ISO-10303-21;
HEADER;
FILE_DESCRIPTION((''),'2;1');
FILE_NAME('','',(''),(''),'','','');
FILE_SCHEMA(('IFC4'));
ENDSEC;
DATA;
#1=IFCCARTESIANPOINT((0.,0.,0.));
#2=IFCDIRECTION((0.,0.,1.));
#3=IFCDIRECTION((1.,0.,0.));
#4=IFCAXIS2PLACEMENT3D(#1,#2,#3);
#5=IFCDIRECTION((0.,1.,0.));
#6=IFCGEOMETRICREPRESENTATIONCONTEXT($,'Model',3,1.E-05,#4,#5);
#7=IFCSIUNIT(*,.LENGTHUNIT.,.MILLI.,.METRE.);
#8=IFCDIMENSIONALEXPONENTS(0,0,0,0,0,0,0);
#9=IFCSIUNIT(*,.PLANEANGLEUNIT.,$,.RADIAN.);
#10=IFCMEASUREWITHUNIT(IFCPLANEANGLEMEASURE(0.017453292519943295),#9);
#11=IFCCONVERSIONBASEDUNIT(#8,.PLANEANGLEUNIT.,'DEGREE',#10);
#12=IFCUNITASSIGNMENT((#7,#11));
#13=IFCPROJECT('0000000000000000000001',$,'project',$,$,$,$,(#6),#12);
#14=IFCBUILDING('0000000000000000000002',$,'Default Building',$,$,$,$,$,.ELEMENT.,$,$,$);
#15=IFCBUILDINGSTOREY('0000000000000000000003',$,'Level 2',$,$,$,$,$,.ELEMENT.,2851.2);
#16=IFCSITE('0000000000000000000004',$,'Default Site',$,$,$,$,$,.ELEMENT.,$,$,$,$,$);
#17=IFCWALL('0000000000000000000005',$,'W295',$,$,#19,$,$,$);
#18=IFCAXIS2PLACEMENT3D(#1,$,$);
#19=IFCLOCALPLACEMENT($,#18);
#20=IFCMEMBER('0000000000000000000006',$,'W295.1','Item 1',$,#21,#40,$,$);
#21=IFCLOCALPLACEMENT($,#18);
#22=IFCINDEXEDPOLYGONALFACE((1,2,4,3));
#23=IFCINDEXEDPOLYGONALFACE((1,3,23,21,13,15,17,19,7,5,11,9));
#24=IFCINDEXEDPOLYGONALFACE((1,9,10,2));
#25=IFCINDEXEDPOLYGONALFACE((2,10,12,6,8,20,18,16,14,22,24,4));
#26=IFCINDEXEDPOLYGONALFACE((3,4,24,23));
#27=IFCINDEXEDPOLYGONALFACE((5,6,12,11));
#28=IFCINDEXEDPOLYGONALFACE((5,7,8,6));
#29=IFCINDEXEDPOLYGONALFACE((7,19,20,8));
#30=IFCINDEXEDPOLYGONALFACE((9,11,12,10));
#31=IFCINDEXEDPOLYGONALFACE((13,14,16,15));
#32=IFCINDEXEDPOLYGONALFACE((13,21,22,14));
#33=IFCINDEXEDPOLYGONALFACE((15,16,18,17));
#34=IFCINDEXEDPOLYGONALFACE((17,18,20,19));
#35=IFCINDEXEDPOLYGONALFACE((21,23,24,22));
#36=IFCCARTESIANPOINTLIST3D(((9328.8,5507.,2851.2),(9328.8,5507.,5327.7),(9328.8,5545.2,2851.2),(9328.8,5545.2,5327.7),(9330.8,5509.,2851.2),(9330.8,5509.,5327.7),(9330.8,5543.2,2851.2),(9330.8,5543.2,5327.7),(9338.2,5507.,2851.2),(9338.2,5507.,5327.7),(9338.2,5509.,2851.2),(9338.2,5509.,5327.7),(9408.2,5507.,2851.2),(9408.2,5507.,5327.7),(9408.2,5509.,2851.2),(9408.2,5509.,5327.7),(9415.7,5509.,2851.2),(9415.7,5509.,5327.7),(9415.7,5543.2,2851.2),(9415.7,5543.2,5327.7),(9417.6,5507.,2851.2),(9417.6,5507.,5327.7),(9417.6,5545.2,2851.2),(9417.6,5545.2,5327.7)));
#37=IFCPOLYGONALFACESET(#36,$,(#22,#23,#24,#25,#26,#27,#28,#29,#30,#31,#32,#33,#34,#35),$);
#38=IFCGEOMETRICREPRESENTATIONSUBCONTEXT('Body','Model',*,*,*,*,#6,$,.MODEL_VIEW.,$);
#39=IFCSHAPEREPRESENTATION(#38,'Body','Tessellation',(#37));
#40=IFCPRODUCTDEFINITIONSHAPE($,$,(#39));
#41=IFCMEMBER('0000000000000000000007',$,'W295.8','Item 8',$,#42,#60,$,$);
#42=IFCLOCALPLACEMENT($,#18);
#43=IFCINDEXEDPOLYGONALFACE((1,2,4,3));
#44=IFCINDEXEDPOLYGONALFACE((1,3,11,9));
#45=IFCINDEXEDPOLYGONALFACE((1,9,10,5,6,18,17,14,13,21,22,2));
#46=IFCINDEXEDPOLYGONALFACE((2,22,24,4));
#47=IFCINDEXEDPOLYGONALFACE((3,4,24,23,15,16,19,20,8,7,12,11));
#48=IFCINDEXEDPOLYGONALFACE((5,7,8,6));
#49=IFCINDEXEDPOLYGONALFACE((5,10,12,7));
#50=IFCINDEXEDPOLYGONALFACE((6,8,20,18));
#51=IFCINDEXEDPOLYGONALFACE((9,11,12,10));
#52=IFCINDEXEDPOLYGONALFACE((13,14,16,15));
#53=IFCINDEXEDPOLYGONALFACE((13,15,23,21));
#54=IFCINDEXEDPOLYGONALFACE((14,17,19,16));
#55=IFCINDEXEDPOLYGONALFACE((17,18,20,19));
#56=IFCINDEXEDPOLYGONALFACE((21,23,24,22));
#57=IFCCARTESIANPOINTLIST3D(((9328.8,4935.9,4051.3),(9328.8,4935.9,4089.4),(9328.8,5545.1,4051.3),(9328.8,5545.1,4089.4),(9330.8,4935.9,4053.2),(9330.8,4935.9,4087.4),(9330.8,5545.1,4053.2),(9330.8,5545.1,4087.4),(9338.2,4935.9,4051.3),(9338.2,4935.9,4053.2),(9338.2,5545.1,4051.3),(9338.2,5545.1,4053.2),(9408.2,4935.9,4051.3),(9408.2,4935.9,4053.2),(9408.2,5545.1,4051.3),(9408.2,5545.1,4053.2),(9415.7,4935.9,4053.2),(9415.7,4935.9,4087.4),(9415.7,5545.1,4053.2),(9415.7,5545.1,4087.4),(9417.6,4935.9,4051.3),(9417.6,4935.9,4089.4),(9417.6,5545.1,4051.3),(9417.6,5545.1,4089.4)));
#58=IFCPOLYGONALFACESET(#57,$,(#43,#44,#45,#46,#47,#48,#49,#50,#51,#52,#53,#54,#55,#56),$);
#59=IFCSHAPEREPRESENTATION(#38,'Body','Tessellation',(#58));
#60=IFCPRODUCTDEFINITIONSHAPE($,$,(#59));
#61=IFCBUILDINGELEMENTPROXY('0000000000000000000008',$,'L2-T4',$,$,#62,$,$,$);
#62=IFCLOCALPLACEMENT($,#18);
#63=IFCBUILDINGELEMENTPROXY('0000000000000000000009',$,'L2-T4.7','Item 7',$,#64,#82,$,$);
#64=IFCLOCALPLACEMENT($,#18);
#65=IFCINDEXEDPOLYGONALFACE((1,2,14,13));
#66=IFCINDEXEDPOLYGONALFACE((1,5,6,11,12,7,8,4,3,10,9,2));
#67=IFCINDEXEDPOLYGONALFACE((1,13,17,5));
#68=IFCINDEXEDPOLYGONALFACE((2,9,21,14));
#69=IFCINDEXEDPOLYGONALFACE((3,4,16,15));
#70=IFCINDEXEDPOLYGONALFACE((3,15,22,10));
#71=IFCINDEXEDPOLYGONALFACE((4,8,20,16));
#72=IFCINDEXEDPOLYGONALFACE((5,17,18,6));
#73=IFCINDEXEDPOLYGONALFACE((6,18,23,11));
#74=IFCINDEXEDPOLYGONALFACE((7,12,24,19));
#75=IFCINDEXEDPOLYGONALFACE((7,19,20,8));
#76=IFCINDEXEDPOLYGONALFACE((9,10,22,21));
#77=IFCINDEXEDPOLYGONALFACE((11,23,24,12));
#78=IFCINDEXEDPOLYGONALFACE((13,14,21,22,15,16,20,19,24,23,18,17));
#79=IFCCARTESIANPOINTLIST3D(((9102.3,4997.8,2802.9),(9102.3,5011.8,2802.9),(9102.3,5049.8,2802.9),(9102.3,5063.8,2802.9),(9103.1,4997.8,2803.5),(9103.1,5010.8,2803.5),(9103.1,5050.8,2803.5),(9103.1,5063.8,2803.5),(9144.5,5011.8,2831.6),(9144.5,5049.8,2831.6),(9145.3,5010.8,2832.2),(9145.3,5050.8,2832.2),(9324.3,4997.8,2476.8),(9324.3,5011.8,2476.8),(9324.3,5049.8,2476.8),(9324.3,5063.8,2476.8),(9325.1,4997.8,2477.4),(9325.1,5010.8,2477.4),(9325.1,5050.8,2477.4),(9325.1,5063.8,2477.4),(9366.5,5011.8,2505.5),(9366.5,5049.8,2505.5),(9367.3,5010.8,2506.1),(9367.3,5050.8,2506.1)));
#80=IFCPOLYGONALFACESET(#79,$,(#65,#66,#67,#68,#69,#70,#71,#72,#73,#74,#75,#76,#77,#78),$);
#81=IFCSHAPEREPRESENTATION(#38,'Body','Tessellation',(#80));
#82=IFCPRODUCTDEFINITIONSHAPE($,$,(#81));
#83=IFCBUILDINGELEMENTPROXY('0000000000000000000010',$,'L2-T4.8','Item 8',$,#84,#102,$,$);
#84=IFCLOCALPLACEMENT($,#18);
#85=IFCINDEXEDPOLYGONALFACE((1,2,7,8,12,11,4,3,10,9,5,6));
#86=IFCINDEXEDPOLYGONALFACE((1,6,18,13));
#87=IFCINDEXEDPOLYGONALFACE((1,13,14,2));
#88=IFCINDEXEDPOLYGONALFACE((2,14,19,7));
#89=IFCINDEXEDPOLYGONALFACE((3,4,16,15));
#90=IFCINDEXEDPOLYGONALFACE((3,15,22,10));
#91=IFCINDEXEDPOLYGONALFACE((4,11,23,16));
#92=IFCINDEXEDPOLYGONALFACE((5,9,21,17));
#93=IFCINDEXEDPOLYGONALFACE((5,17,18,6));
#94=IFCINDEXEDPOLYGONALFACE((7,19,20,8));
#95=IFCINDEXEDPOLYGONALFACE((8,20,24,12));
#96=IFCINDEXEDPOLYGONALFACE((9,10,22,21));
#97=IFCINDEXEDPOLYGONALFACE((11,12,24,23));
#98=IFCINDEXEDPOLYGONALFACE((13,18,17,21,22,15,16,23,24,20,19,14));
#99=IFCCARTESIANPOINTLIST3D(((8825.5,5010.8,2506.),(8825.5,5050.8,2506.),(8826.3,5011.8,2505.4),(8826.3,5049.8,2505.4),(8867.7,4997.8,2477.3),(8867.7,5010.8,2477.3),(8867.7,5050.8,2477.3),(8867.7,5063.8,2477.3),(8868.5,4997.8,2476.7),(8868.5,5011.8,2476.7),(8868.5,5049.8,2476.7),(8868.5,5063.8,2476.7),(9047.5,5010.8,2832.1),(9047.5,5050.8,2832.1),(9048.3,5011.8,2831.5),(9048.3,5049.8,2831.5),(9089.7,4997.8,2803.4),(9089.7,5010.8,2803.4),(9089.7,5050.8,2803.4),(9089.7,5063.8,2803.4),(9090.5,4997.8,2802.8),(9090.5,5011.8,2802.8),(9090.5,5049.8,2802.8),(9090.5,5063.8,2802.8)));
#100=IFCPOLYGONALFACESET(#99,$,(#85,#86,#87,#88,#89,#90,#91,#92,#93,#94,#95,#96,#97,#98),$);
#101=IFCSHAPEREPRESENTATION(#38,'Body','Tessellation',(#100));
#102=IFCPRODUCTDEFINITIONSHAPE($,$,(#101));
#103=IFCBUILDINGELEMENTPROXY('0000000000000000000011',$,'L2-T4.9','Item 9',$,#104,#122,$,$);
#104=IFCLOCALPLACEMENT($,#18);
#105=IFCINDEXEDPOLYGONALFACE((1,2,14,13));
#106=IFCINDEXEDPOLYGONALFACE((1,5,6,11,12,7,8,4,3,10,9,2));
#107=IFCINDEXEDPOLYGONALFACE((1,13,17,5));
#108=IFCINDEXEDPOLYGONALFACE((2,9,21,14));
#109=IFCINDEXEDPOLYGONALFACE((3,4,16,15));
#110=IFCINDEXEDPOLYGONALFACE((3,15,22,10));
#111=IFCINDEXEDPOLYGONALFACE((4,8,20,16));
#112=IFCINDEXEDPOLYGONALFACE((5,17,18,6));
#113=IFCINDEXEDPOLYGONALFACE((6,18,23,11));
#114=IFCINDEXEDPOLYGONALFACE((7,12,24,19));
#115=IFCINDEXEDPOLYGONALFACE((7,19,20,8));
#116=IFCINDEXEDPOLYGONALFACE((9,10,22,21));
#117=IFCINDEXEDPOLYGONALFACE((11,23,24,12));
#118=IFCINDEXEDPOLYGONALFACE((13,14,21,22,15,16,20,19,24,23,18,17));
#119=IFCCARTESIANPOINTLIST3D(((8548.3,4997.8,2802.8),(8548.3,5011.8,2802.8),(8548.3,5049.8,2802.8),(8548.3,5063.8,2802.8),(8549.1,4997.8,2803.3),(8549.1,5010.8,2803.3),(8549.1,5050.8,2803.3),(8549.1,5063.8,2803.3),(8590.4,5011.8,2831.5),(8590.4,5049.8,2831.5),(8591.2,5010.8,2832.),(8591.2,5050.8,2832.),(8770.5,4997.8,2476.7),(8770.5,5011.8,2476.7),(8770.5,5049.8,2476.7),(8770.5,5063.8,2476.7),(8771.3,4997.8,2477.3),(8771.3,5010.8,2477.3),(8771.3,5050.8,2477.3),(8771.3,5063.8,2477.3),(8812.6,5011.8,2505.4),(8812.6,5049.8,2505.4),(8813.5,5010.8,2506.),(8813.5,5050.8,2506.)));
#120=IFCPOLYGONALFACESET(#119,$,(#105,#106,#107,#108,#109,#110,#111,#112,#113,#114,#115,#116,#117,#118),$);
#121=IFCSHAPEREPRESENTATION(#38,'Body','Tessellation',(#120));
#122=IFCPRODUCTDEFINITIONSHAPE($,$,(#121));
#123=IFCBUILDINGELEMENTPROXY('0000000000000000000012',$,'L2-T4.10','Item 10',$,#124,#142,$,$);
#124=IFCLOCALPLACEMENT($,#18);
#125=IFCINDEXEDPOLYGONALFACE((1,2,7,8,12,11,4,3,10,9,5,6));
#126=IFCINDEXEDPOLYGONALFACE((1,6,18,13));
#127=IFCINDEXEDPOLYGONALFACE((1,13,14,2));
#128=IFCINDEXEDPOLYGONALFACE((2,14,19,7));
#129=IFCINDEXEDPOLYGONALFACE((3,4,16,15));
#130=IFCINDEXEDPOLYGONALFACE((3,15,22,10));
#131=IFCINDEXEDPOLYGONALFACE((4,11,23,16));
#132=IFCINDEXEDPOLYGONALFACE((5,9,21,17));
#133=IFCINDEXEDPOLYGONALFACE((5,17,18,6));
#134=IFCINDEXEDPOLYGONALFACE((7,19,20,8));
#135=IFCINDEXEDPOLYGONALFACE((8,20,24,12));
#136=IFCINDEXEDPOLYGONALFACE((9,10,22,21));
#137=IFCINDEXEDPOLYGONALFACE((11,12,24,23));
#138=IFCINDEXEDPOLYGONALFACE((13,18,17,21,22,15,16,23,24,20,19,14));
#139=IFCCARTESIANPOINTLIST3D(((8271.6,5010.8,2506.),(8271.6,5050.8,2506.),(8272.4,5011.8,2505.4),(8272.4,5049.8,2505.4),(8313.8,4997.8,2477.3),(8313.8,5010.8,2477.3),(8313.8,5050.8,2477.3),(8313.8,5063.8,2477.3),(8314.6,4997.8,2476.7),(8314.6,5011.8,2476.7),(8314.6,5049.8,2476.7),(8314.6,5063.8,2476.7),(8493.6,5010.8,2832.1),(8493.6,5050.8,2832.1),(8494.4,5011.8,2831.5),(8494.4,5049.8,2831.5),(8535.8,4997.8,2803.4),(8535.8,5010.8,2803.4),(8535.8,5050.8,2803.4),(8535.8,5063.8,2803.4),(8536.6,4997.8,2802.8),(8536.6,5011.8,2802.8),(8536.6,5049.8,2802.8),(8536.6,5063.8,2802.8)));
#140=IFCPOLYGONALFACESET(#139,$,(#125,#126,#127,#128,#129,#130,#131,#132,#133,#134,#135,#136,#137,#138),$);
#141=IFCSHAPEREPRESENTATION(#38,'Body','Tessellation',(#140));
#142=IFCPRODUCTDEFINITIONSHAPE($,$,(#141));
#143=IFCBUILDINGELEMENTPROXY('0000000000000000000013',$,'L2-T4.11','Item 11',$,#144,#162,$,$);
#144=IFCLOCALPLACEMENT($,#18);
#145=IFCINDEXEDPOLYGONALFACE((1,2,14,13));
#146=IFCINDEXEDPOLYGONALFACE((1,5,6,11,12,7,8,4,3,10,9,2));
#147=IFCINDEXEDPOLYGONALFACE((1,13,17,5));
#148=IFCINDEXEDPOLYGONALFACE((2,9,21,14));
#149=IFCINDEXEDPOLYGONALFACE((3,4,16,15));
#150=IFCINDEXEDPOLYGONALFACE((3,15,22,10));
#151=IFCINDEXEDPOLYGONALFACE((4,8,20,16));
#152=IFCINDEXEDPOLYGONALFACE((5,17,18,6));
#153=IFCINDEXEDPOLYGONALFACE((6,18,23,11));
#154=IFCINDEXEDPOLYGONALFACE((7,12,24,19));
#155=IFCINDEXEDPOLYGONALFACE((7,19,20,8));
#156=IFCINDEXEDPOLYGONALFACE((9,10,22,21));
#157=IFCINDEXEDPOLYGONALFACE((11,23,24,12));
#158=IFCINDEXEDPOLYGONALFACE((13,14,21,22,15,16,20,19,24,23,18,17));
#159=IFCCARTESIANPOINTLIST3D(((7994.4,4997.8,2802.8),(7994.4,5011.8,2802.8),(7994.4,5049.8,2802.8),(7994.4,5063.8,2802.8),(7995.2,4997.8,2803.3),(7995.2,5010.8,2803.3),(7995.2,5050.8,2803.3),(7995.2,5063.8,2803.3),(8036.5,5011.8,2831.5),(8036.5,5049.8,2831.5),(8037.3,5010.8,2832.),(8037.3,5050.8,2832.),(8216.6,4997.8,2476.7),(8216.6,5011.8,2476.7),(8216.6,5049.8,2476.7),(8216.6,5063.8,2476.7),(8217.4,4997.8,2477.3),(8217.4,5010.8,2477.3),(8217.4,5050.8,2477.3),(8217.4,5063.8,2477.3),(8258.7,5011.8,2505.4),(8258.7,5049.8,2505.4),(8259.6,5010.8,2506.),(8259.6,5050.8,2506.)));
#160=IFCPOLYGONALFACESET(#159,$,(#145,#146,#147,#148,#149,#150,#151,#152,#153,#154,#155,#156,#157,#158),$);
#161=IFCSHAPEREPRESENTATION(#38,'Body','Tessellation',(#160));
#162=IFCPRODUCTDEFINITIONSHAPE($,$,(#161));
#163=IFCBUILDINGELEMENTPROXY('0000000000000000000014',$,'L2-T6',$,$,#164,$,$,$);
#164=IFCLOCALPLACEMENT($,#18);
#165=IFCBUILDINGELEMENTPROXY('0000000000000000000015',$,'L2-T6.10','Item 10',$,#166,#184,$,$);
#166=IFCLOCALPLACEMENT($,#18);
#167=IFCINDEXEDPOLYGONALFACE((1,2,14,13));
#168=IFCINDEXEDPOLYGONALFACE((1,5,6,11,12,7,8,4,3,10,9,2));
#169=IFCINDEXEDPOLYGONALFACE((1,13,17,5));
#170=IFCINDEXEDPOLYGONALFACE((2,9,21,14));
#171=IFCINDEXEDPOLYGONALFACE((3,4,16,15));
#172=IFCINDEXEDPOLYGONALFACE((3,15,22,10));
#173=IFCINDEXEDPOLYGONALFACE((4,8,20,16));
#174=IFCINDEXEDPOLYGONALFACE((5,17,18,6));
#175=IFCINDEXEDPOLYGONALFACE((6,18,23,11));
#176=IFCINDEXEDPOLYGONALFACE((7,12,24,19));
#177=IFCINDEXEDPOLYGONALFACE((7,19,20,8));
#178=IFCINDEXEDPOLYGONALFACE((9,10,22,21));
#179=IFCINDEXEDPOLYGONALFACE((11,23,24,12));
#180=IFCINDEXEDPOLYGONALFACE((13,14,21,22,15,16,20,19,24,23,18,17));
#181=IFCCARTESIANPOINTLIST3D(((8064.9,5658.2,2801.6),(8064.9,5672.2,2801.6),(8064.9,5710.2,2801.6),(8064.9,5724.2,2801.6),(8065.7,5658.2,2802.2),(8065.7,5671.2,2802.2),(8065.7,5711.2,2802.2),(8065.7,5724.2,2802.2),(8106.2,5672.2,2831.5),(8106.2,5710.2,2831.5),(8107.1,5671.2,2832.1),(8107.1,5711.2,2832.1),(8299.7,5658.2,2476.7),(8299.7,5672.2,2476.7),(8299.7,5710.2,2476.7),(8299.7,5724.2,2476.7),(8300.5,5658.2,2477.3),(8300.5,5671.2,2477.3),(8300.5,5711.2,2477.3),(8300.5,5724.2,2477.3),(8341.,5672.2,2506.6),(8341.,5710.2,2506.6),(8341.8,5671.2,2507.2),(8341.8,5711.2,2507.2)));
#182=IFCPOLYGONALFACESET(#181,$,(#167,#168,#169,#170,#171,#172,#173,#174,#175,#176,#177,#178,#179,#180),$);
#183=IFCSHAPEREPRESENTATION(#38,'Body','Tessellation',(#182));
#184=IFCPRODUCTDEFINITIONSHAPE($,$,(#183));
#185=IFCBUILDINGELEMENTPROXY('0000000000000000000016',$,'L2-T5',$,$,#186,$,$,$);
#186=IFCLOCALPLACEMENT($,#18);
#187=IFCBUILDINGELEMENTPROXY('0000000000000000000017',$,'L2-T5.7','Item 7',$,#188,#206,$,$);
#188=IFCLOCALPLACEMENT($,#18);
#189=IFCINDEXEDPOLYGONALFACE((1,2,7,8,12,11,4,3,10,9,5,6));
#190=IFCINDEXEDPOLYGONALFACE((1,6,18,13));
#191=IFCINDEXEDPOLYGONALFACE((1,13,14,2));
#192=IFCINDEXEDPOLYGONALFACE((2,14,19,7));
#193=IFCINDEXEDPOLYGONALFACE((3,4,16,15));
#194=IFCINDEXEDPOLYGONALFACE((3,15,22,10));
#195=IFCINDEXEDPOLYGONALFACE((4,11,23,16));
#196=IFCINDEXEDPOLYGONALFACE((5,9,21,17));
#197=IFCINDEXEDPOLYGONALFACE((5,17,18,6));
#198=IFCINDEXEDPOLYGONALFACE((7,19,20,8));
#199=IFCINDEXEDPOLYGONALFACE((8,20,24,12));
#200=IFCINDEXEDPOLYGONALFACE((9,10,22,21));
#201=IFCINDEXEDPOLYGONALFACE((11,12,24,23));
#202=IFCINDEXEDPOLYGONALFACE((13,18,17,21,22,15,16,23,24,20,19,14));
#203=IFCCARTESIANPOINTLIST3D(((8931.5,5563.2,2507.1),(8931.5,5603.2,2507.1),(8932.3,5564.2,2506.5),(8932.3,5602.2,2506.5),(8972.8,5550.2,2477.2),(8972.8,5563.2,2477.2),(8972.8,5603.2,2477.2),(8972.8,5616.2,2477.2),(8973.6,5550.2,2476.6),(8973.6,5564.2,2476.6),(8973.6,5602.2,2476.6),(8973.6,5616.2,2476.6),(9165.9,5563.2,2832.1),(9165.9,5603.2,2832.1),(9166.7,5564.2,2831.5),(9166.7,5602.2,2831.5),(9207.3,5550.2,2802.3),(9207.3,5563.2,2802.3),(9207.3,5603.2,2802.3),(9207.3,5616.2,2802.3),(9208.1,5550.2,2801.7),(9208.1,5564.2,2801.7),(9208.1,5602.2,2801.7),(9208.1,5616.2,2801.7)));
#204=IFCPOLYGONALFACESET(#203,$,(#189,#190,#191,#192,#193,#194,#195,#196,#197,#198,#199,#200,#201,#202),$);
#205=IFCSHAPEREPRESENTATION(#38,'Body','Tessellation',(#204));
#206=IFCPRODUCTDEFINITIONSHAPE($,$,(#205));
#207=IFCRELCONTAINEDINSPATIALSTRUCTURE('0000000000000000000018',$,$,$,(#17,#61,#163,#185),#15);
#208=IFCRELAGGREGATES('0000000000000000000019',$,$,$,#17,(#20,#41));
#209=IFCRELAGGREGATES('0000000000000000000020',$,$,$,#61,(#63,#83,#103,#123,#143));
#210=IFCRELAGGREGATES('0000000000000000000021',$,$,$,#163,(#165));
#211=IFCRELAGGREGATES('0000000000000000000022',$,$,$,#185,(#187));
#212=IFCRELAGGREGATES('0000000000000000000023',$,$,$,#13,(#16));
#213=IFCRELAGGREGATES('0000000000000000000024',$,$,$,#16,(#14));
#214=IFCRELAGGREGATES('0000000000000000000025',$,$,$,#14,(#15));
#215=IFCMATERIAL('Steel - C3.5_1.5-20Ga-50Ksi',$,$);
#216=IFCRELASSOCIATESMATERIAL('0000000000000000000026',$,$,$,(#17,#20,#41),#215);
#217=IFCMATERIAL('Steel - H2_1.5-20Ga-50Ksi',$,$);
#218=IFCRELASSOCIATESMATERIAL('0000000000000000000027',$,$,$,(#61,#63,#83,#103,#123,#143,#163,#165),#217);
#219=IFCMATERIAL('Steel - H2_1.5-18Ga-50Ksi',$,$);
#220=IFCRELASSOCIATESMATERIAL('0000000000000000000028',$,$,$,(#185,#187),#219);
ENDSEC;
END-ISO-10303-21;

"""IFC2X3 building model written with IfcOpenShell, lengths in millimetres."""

from ifc_helpers import new_model, entity, si_unit, converted_unit, direction, frame, origin, origin_with_axes, origin_2d_with_axis, place, context, subcontext, project, spatial, polyline, c_section, outline, extrude, material, element, aggregate, save


model = new_model("IFC2X3")

# Units and contexts
model_context = context("Model", 3, precision=1e-05, world=origin_with_axes(), true_north=direction((0.0, 1.0, 0.0)))
body_context = subcontext(model_context, "Body", "Model", "MODEL_VIEW")
ifc_project = project(units=[si_unit("LENGTHUNIT", "METRE", prefix="MILLI"), converted_unit("PLANEANGLEUNIT", "DEGREE", entity("IfcPlaneAngleMeasure", 0.017453292519943295), si_unit("PLANEANGLEUNIT", "RADIAN"), dimensions=[0, 0, 0, 0, 0, 0, 0])], contexts=[model_context])

# Site, building, storey
site = spatial("IfcSite", under=ifc_project, Name="Default Site", CompositionType="ELEMENT")
building = spatial("IfcBuilding", under=site, Name="Default Building", CompositionType="ELEMENT")
storey = spatial("IfcBuildingStorey", under=building, Name="Level 2", CompositionType="ELEMENT", Elevation=2851.2)

# Wall, members
ifc_material_1 = material(Name="Steel - C3.5_1.5-20Ga-50Ksi")
wall_1 = element("IfcWall", 1, inside=storey, material=ifc_material_1, Name="W295")
member_1_placement = place(None, frame((9373.2, 5526.1, 2851.2), z_axis=(0.0, 0.0, 1.0), x_axis=(0.0, -1.0, 0.0)))
member_1 = element("IfcMember", 2, at=member_1_placement, material=ifc_material_1, Name="W295.1", Description="Item 1", context=body_context, shape_type="SweptSolid", body=[
    extrude(c_section(Depth=88.9, Width=38.1, WallThickness=2.0, Girth=9.5, at=origin_2d_with_axis()), origin(), (0.0, 0.0, 1.0), 2476.5),
])
member_2_placement = place(None, frame((9373.2, 5545.1, 4070.3), z_axis=(0.0, -1.0, 0.0), x_axis=(0.0, 0.0, -1.0)))
member_2 = element("IfcMember", 3, at=member_2_placement, material=ifc_material_1, Name="W295.8", Description="Item 8", context=body_context, shape_type="SweptSolid", body=[
    extrude(c_section(Depth=88.9, Width=38.1, WallThickness=2.0, Girth=9.5, at=origin_2d_with_axis()), origin(), (0.0, 0.0, 1.0), 609.2),
])
aggregate(wall_1, [member_1, member_2])

# Building element proxies
ifc_material_2 = material(Name="Steel - H2_1.5-20Ga-50Ksi")
proxy_1 = element("IfcBuildingElementProxy", 4, inside=storey, material=ifc_material_2, Name="L2-T4")
proxy_2_placement = place(None, frame((9324.3, 5063.8, 2476.8), z_axis=(-0.563, 0.0, 0.827), x_axis=(0.0, -40.0, 0.0)))
proxy_2 = element("IfcBuildingElementProxy", 5, at=proxy_2_placement, material=ifc_material_2, Name="L2-T4.7", Description="Item 7", context=body_context, shape_type="SweptSolid", body=[
    extrude(outline(polyline([(0.0, 0.0), (14.0, 0.0), (14.0, 51.0), (52.0, 51.0), (52.0, 0.0), (66.0, 0.0), (66.0, 1.0), (53.0, 1.0), (53.0, 52.0), (13.0, 52.0), (13.0, 1.0), (0.0, 1.0), (0.0, 0.0)])), origin(), (0.0, 0.0, 1.0), 394.5),
])
proxy_3_placement = place(None, frame((9090.5, 5063.8, 2802.8), z_axis=(-0.563, 0.0, -0.827), x_axis=(0.0, -40.0, 0.0)))
proxy_3 = element("IfcBuildingElementProxy", 6, at=proxy_3_placement, material=ifc_material_2, Name="L2-T4.8", Description="Item 8", context=body_context, shape_type="SweptSolid", body=[
    extrude(outline(polyline([(0.0, 0.0), (14.0, 0.0), (14.0, 51.0), (52.0, 51.0), (52.0, 0.0), (66.0, 0.0), (66.0, 1.0), (53.0, 1.0), (53.0, 52.0), (13.0, 52.0), (13.0, 1.0), (0.0, 1.0), (0.0, 0.0)])), origin(), (0.0, 0.0, 1.0), 394.5),
])
proxy_4_placement = place(None, frame((8770.5, 5063.8, 2476.7), z_axis=(-0.563, 0.0, 0.826), x_axis=(0.0, -40.0, 0.0)))
proxy_4 = element("IfcBuildingElementProxy", 7, at=proxy_4_placement, material=ifc_material_2, Name="L2-T4.9", Description="Item 9", context=body_context, shape_type="SweptSolid", body=[
    extrude(outline(polyline([(0.0, 0.0), (14.0, 0.0), (14.0, 51.0), (52.0, 51.0), (52.0, 0.0), (66.0, 0.0), (66.0, 1.0), (53.0, 1.0), (53.0, 52.0), (13.0, 52.0), (13.0, 1.0), (0.0, 1.0), (0.0, 0.0)])), origin(), (0.0, 0.0, 1.0), 394.6),
])
proxy_5_placement = place(None, frame((8536.6, 5063.8, 2802.8), z_axis=(-0.563, 0.0, -0.827), x_axis=(0.0, -40.0, 0.0)))
proxy_5 = element("IfcBuildingElementProxy", 8, at=proxy_5_placement, material=ifc_material_2, Name="L2-T4.10", Description="Item 10", context=body_context, shape_type="SweptSolid", body=[
    extrude(outline(polyline([(0.0, 0.0), (14.0, 0.0), (14.0, 51.0), (52.0, 51.0), (52.0, 0.0), (66.0, 0.0), (66.0, 1.0), (53.0, 1.0), (53.0, 52.0), (13.0, 52.0), (13.0, 1.0), (0.0, 1.0), (0.0, 0.0)])), origin(), (0.0, 0.0, 1.0), 394.5),
])
proxy_6_placement = place(None, frame((8216.6, 5063.8, 2476.7), z_axis=(-0.563, 0.0, 0.826), x_axis=(0.0, -40.0, 0.0)))
proxy_6 = element("IfcBuildingElementProxy", 9, at=proxy_6_placement, material=ifc_material_2, Name="L2-T4.11", Description="Item 11", context=body_context, shape_type="SweptSolid", body=[
    extrude(outline(polyline([(0.0, 0.0), (14.0, 0.0), (14.0, 51.0), (52.0, 51.0), (52.0, 0.0), (66.0, 0.0), (66.0, 1.0), (53.0, 1.0), (53.0, 52.0), (13.0, 52.0), (13.0, 1.0), (0.0, 1.0), (0.0, 0.0)])), origin(), (0.0, 0.0, 1.0), 394.6),
])
aggregate(proxy_1, [proxy_2, proxy_3, proxy_4, proxy_5, proxy_6])
proxy_7 = element("IfcBuildingElementProxy", 10, inside=storey, material=ifc_material_2, Name="L2-T6")
proxy_8_placement = place(None, frame((8299.7, 5724.2, 2476.7), z_axis=(-0.586, 0.0, 0.811), x_axis=(0.0, -40.0, 0.0)))
proxy_8 = element("IfcBuildingElementProxy", 11, at=proxy_8_placement, material=ifc_material_2, Name="L2-T6.10", Description="Item 10", context=body_context, shape_type="SweptSolid", body=[
    extrude(outline(polyline([(0.0, 0.0), (14.0, 0.0), (14.0, 51.0), (52.0, 51.0), (52.0, 0.0), (66.0, 0.0), (66.0, 1.0), (53.0, 1.0), (53.0, 52.0), (13.0, 52.0), (13.0, 1.0), (0.0, 1.0), (0.0, 0.0)])), origin(), (0.0, 0.0, 1.0), 400.9),
])
aggregate(proxy_7, [proxy_8])
ifc_material_3 = material(Name="Steel - H2_1.5-18Ga-50Ksi")
proxy_9 = element("IfcBuildingElementProxy", 12, inside=storey, material=ifc_material_3, Name="L2-T5")
proxy_10_placement = place(None, frame((9208.1, 5616.2, 2801.7), z_axis=(-0.585, 0.0, -0.811), x_axis=(0.0, -40.0, 0.0)))
proxy_10 = element("IfcBuildingElementProxy", 13, at=proxy_10_placement, material=ifc_material_3, Name="L2-T5.7", Description="Item 7", context=body_context, shape_type="SweptSolid", body=[
    extrude(outline(polyline([(0.0, 0.0), (14.0, 0.0), (14.0, 51.0), (52.0, 51.0), (52.0, 0.0), (66.0, 0.0), (66.0, 1.0), (53.0, 1.0), (53.0, 52.0), (13.0, 52.0), (13.0, 1.0), (0.0, 1.0), (0.0, 0.0)])), origin(), (0.0, 0.0, 1.0), 400.8),
])
aggregate(proxy_9, [proxy_10])

save(model, "model.ifc")
